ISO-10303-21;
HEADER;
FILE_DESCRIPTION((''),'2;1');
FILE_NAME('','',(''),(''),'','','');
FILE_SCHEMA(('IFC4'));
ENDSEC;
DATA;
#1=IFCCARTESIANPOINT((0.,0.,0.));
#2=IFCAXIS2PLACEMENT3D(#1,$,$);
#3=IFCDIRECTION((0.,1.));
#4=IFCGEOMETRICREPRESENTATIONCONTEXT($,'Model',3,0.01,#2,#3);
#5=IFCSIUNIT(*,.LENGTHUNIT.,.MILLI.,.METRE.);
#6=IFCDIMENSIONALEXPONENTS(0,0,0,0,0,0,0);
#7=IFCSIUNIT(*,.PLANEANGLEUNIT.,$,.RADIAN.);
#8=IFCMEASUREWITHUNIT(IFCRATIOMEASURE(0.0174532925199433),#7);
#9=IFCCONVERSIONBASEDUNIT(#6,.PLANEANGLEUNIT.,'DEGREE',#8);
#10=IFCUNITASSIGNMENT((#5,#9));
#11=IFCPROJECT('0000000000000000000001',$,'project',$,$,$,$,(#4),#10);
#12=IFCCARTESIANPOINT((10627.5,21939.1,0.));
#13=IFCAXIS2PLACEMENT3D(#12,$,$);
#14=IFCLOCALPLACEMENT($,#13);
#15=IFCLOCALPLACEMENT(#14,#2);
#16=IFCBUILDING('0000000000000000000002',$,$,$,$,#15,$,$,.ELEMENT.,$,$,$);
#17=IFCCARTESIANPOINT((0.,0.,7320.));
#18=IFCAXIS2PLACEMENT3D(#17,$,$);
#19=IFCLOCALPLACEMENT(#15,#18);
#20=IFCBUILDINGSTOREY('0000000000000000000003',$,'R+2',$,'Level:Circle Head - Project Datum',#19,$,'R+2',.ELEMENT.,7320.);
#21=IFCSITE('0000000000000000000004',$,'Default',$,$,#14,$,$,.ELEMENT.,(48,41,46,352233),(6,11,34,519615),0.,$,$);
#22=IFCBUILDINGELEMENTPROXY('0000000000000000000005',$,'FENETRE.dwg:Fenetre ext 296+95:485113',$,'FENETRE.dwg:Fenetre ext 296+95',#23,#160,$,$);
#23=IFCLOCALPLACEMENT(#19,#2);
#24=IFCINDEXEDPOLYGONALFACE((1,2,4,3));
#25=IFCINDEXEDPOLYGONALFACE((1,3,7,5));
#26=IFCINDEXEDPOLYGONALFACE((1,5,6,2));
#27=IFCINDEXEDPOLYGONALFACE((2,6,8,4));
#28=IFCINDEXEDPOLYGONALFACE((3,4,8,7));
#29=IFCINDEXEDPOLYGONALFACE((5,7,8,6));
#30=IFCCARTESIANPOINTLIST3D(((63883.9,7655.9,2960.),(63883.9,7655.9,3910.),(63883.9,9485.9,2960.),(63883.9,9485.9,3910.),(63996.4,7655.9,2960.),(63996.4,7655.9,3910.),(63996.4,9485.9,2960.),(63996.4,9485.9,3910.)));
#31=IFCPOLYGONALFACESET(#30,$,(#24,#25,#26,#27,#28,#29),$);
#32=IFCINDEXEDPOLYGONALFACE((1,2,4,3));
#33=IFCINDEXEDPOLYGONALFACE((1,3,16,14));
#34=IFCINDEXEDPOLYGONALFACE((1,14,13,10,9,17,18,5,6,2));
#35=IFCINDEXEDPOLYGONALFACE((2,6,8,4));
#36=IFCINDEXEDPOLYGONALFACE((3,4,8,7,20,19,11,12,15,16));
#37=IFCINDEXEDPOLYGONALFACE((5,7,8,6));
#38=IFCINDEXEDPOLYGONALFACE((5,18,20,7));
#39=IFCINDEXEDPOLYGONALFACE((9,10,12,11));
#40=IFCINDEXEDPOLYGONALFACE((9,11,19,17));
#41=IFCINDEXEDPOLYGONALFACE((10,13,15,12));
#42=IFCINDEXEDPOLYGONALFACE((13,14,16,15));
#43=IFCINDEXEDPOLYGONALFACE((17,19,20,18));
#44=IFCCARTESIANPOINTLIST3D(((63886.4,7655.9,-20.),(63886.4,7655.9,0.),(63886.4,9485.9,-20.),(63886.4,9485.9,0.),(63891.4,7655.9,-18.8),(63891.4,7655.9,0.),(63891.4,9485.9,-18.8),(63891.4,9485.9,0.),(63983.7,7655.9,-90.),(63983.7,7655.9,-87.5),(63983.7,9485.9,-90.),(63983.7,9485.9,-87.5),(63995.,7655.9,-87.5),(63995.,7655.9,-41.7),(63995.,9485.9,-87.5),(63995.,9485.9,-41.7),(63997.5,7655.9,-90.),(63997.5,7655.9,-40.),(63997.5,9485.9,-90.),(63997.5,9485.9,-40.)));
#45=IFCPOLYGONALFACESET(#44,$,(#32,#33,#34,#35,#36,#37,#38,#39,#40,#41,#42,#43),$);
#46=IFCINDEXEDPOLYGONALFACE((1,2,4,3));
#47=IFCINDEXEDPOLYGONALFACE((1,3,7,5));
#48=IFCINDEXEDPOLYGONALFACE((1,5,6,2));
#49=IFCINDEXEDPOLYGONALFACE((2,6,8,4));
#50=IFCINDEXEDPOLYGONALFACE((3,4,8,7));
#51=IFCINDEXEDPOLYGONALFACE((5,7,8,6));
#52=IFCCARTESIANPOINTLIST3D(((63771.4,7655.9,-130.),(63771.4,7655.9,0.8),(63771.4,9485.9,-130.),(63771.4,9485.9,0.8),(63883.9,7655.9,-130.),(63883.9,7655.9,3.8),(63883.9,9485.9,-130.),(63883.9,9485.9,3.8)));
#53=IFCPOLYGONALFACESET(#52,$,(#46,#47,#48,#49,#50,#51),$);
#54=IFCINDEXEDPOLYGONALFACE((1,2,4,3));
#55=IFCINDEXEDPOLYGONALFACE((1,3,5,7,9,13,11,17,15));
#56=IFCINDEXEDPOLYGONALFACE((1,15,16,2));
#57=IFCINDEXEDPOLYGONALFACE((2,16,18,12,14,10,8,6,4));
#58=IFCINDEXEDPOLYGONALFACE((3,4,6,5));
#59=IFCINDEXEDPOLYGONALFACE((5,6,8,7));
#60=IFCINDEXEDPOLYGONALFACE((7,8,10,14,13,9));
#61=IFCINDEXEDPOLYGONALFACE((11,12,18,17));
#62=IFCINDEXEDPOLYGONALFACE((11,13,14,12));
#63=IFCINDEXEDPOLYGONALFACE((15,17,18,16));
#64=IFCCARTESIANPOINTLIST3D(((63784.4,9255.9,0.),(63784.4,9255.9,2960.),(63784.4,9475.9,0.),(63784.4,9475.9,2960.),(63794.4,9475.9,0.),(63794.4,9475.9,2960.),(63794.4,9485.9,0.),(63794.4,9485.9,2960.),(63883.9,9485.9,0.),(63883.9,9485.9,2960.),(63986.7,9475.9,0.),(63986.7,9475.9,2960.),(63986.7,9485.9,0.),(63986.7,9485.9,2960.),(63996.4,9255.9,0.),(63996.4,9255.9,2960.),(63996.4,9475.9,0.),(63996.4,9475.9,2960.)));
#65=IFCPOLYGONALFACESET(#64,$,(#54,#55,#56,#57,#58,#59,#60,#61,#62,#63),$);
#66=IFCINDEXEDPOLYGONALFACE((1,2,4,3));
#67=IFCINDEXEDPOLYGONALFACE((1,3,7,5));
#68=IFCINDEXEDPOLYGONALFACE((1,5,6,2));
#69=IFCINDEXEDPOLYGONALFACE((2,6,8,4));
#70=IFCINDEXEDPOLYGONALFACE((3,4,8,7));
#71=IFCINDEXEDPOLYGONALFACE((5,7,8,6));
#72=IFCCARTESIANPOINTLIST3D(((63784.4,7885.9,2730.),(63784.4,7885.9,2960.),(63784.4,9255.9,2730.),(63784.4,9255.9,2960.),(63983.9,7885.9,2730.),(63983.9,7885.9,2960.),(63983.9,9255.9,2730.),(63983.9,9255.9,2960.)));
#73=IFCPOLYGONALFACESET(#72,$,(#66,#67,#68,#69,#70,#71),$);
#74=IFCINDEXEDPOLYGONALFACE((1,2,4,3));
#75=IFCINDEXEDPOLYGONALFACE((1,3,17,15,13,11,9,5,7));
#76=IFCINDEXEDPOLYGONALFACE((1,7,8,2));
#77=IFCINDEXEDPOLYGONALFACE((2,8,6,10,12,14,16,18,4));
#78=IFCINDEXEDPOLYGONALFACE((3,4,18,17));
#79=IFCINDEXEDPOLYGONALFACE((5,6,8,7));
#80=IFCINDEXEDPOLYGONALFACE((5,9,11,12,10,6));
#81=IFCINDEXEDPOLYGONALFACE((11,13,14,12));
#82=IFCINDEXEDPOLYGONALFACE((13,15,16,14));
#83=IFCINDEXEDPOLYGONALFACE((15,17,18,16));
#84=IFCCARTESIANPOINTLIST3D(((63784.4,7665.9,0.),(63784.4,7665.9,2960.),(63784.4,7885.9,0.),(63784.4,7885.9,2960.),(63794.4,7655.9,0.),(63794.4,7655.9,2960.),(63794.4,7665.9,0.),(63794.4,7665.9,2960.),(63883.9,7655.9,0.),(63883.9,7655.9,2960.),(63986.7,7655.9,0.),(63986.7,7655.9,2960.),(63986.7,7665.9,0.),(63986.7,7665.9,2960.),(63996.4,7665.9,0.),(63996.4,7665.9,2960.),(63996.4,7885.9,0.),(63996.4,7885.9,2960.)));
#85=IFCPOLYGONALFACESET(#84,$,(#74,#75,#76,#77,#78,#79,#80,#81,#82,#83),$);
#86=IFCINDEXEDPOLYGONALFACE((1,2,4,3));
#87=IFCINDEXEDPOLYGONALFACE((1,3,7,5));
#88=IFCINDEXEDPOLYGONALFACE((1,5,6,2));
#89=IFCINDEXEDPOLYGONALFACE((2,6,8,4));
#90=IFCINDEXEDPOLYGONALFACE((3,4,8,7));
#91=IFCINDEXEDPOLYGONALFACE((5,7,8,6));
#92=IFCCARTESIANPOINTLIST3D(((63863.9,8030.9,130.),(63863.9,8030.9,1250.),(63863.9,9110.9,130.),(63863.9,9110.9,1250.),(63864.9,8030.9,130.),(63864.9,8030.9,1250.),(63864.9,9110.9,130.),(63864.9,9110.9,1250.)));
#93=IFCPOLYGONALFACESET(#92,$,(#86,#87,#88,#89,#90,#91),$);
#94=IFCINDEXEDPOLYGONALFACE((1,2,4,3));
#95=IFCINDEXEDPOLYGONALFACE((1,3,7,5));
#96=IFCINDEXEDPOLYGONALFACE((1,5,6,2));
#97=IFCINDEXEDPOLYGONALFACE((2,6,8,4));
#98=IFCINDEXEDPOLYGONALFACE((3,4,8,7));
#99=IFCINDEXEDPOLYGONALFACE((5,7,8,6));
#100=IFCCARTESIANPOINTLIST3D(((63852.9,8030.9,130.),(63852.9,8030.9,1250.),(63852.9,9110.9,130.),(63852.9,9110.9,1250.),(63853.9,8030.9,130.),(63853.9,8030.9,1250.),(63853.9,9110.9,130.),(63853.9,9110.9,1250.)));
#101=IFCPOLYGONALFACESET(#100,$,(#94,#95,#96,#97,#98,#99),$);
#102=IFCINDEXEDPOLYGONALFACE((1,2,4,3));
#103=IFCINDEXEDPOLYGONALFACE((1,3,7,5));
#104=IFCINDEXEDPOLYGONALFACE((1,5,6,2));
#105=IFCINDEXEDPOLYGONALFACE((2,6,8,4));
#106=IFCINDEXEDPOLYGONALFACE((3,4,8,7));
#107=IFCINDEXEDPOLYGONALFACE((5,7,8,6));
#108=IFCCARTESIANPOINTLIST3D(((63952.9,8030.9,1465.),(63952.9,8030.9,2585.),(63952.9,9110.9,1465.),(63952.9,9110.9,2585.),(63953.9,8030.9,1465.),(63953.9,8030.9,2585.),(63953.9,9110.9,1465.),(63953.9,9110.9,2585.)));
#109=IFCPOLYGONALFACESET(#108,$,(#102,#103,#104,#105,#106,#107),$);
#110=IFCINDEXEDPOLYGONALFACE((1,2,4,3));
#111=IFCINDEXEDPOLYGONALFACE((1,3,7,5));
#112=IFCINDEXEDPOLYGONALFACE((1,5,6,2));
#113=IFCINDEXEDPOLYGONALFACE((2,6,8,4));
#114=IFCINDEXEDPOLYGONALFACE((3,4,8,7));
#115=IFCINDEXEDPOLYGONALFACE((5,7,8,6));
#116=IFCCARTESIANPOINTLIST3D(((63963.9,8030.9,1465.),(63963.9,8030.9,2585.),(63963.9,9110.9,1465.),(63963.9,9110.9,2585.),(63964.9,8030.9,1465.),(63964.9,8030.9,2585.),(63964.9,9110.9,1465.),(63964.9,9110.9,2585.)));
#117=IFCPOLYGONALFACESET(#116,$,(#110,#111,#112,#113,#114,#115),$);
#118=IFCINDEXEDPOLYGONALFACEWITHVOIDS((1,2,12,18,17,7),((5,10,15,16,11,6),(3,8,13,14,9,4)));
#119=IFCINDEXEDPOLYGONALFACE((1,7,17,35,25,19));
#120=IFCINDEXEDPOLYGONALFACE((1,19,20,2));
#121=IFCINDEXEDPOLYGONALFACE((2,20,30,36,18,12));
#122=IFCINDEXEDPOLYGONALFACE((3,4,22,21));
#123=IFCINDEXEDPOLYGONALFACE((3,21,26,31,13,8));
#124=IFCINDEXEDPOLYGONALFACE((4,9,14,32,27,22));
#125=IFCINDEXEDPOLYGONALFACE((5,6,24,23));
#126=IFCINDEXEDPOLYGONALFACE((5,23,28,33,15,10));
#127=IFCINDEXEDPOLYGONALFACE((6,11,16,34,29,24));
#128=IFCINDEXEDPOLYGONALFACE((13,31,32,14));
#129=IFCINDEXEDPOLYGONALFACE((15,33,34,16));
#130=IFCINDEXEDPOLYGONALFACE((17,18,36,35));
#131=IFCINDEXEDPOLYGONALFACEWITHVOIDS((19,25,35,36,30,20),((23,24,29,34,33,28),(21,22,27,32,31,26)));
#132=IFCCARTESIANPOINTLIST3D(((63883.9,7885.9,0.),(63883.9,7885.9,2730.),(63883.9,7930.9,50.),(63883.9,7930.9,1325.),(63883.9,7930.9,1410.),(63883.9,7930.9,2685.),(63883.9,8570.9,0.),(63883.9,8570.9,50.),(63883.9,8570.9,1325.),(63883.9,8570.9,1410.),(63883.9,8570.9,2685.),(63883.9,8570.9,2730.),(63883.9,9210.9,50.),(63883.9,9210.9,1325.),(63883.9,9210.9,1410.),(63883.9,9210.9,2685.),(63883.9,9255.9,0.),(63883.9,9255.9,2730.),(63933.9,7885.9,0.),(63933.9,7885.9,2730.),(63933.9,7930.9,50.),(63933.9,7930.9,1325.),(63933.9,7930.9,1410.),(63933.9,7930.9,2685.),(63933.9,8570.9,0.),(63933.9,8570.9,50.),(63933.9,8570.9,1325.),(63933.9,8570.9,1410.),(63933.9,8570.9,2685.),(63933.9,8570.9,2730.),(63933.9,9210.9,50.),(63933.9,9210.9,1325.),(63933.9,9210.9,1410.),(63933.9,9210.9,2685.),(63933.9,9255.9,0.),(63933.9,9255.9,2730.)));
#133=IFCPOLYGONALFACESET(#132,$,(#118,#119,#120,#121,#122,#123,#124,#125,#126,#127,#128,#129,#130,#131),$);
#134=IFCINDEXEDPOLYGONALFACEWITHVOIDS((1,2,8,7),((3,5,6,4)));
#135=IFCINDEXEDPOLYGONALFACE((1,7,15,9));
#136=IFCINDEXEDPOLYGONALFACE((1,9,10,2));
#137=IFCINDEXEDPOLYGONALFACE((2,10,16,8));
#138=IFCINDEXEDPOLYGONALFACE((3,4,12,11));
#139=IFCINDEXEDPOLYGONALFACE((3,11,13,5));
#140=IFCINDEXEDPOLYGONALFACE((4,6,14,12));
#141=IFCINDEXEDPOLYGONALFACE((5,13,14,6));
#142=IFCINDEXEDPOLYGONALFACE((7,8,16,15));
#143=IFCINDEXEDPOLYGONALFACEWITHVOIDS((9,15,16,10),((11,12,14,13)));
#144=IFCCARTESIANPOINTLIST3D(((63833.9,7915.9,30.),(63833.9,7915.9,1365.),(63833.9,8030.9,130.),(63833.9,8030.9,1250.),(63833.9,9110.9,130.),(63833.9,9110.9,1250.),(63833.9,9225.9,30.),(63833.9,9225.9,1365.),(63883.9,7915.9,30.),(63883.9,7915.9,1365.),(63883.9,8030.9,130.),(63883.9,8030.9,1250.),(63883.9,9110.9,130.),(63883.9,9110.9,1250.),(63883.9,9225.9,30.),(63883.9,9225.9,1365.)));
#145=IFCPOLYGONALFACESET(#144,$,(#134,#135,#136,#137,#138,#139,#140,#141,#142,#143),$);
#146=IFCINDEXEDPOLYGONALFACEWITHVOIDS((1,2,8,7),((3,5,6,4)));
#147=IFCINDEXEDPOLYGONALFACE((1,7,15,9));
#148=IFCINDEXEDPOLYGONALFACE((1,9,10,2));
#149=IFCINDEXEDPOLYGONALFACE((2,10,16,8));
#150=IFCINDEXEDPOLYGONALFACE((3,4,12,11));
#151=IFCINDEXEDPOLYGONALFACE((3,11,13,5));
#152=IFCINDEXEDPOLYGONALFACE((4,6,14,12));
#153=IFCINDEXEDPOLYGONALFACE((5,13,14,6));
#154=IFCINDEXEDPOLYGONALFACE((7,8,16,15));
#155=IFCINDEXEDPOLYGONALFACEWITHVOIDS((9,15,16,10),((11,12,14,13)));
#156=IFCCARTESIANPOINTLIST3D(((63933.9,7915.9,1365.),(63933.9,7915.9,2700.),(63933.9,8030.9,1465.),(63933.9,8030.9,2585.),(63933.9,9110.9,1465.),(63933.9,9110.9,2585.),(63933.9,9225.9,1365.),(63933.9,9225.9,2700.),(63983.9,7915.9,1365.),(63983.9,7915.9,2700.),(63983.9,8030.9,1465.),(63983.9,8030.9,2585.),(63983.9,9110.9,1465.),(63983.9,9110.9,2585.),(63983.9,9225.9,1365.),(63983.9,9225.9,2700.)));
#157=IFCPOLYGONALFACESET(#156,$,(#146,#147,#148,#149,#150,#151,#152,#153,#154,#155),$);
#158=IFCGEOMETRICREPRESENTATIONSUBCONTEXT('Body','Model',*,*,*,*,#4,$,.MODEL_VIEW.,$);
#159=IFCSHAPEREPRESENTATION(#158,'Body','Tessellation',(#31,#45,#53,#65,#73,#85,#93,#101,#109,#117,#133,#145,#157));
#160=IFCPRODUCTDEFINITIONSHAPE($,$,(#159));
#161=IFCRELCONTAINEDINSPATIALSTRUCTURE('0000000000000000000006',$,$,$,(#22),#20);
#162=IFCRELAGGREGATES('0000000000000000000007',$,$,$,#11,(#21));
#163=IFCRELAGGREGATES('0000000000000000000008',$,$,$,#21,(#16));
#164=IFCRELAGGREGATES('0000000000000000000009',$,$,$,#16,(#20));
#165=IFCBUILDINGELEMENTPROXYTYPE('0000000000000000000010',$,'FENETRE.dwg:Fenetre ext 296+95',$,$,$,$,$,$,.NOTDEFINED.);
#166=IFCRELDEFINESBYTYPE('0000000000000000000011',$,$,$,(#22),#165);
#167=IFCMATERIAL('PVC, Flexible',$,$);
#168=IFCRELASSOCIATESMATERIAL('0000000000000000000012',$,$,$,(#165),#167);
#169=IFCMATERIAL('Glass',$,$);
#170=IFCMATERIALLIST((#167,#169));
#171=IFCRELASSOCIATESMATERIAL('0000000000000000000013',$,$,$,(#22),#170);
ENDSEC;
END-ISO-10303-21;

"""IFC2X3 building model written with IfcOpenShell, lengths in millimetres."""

from ifc_helpers import new_model, entity, si_unit, converted_unit, direction, frame, frame_2d, origin, origin_2d_with_axis, place, context, subcontext, project, spatial, polyline, rectangle, outline, extrude, source, transform, mapped, material, material_list, type_object, type_shapes, element, save


model = new_model("IFC2X3")

# Units and contexts
model_context = context("Model", 3, precision=0.01, world=origin(), true_north=direction((0.0, 1.0)))
body_context = subcontext(model_context, "Body", "Model", "MODEL_VIEW")
ifc_project = project(units=[si_unit("LENGTHUNIT", "METRE", prefix="MILLI"), converted_unit("PLANEANGLEUNIT", "DEGREE", entity("IfcRatioMeasure", 0.0174532925199433), si_unit("PLANEANGLEUNIT", "RADIAN"), dimensions=[0, 0, 0, 0, 0, 0, 0])], contexts=[model_context])

# Site, building, storey
site_placement = place(None, frame((10627.5, 21939.1, 0.0)))
site = spatial("IfcSite", under=ifc_project, at=site_placement, Name="Default", CompositionType="ELEMENT", RefLatitude=(48, 41, 46, 352233), RefLongitude=(6, 11, 34, 519615), RefElevation=0.0)
building_placement = place(site_placement, origin())
building = spatial("IfcBuilding", under=site, at=building_placement, CompositionType="ELEMENT")
storey_placement = place(building_placement, frame((0.0, 0.0, 7320.0)))
storey = spatial("IfcBuildingStorey", under=building, at=storey_placement, Name="R+2", ObjectType="Level:Circle Head - Project Datum", LongName="R+2", CompositionType="ELEMENT", Elevation=7320.0)

# Building element proxy
ifc_material_1 = material(Name="PVC, Flexible")
ifc_material_2 = material(Name="Glass")
building_element_proxy_type_1 = type_object("IfcBuildingElementProxyType", Name="FENETRE.dwg:Fenetre ext 296+95", PredefinedType="NOTDEFINED", material=ifc_material_1)
shared_shape_1 = source(origin(), body_context, "Body", "SweptSolid", [
    extrude(rectangle(XDim=112.5, YDim=1830.0, at=origin_2d_with_axis()), frame((-10.4, -56.3, 2960.0), z_axis=(0.0, 0.0, 1.0), x_axis=(0.0, 1.0, 0.0)), (0.0, 0.0, 1.0), 950.0),
    extrude(outline(polyline([(27.5, -64.4), (47.5, -64.4), (47.5, -59.4), (28.8, -59.4), (7.5, 46.7), (-42.5, 46.7), (-42.5, 32.9), (-40.0, 32.9), (-40.0, 44.2), (5.8, 44.2), (27.5, -64.4)])), frame((-925.4, -66.9, -47.5), z_axis=(1.0, 0.0, 0.0), x_axis=(0.0, 0.0, 1.0)), (0.0, 0.0, 1.0), 1830.0),
    extrude(outline(polyline([(-54.5, -66.1), (58.0, -66.1), (54.5, 67.6), (-58.0, 64.6), (-54.5, -66.1)])), frame((-925.4, 56.3, -63.8), z_axis=(1.0, 0.0, 0.0), x_axis=(0.0, -0.999645, 0.02665)), (0.0, 0.0, 1.0), 1830.0),
    extrude(outline(polyline([(-97.0, -55.6), (5.9, -55.6), (95.4, -55.6), (95.4, -45.6), (105.4, -45.6), (105.4, 174.4), (-106.6, 174.4), (-106.6, -45.6), (-97.0, -45.6), (-97.0, -55.6)])), frame((849.0, -5.9, 0.0), z_axis=(0.0, 0.0, 1.0), x_axis=(0.0, 1.0, 0.0)), (0.0, 0.0, 1.0), 2960.0),
    extrude(rectangle(XDim=1370.0, YDim=199.5, at=origin_2d_with_axis()), frame((-10.4, -0.3, 2730.0), z_axis=(0.0, 0.0, 1.0), x_axis=(-1.0, 0.0, 0.0)), (0.0, 0.0, 1.0), 230.0),
    extrude(outline(polyline([(-55.6, 97.0), (-55.6, -5.9), (-55.6, -95.4), (-45.6, -95.4), (-45.6, -105.4), (174.4, -105.4), (174.4, 106.6), (-45.6, 106.6), (-45.6, 97.0), (-55.6, 97.0)])), frame((-869.9, -5.9, 0.0), z_axis=(0.0, 0.0, -1.0), x_axis=(1.0, 0.0, 0.0)), (0.0, 0.0, -1.0), 2960.0),
    extrude(rectangle(XDim=1080.0, YDim=1.0, at=origin_2d_with_axis()), frame((-10.4, 19.5, 130.0), z_axis=(0.0, 0.0, 1.0), x_axis=(-1.0, 0.0, 0.0)), (0.0, 0.0, 1.0), 1120.0),
    extrude(rectangle(XDim=1080.0, YDim=1.0, at=origin_2d_with_axis()), frame((-10.4, 30.5, 130.0), z_axis=(0.0, 0.0, 1.0), x_axis=(-1.0, 0.0, 0.0)), (0.0, 0.0, 1.0), 1120.0),
    extrude(rectangle(XDim=1080.0, YDim=1.0, at=frame_2d((0.0, 0.0), x_axis=(1.0, 0.0))), frame((-10.4, -69.5, 1465.0), z_axis=(0.0, 0.0, 1.0), x_axis=(-1.0, 0.0, 0.0)), (0.0, 0.0, 1.0), 1120.0),
    extrude(rectangle(XDim=1080.0, YDim=1.0, at=frame_2d((0.0, 0.0), x_axis=(1.0, 0.0))), frame((-10.4, -80.5, 1465.0), z_axis=(0.0, 0.0, 1.0), x_axis=(-1.0, 0.0, 0.0)), (0.0, 0.0, 1.0), 1120.0),
    extrude(outline(polyline([(-685.0, -1365.0), (0.0, -1365.0), (685.0, -1365.0), (685.0, 1365.0), (0.0, 1365.0), (-685.0, 1365.0), (-685.0, -1365.0)]), holes=[polyline([(-640.0, -1320.0), (-640.0, -45.0), (0.0, -45.0), (640.0, -45.0), (640.0, -1320.0), (0.0, -1320.0), (-640.0, -1320.0)]), polyline([(-640.0, 40.0), (-640.0, 1315.0), (0.0, 1315.0), (640.0, 1315.0), (640.0, 40.0), (0.0, 40.0), (-640.0, 40.0)])]), frame((-10.4, -50.0, 1365.0), z_axis=(0.0, 1.0, 0.0), x_axis=(1.0, 0.0, 0.0)), (0.0, 0.0, 1.0), 50.0),
    extrude(outline(polyline([(-655.0, -667.5), (655.0, -667.5), (655.0, 667.5), (-655.0, 667.5), (-655.0, -667.5)]), holes=[polyline([(-540.0, 552.5), (540.0, 552.5), (540.0, -567.5), (-540.0, -567.5), (-540.0, 552.5)])]), frame((-10.4, 0.0, 697.5), z_axis=(0.0, 1.0, 0.0), x_axis=(-1.0, 0.0, 0.0)), (0.0, 0.0, 1.0), 50.0),
    extrude(outline(polyline([(-655.0, -667.5), (655.0, -667.5), (655.0, 667.5), (-655.0, 667.5), (-655.0, -667.5)]), holes=[polyline([(-540.0, 552.5), (540.0, 552.5), (540.0, -567.5), (-540.0, -567.5), (-540.0, 552.5)])]), frame((-10.4, -100.0, 2032.5), z_axis=(0.0, 1.0, 0.0), x_axis=(-1.0, 0.0, 0.0)), (0.0, 0.0, 1.0), 50.0),
])
type_shapes(building_element_proxy_type_1, [shared_shape_1])
ifc_material_list_1 = material_list([ifc_material_1, ifc_material_2])
proxy_1_placement = place(storey_placement, frame((63883.9, 8581.3, 0.0), z_axis=(0.0, 0.0, 1.0), x_axis=(0.0, 1.0, 0.0)))
element("IfcBuildingElementProxy", 1, at=proxy_1_placement, inside=storey, type_object=building_element_proxy_type_1, material=ifc_material_list_1, Name="FENETRE.dwg:Fenetre ext 296+95:485113", ObjectType="FENETRE.dwg:Fenetre ext 296+95", context=body_context, shape_type="MappedRepresentation", body=[
    mapped(shared_shape_1, transform((0.0, 0.0, 0.0), scale=1.0)),
])

save(model, "model.ifc")
